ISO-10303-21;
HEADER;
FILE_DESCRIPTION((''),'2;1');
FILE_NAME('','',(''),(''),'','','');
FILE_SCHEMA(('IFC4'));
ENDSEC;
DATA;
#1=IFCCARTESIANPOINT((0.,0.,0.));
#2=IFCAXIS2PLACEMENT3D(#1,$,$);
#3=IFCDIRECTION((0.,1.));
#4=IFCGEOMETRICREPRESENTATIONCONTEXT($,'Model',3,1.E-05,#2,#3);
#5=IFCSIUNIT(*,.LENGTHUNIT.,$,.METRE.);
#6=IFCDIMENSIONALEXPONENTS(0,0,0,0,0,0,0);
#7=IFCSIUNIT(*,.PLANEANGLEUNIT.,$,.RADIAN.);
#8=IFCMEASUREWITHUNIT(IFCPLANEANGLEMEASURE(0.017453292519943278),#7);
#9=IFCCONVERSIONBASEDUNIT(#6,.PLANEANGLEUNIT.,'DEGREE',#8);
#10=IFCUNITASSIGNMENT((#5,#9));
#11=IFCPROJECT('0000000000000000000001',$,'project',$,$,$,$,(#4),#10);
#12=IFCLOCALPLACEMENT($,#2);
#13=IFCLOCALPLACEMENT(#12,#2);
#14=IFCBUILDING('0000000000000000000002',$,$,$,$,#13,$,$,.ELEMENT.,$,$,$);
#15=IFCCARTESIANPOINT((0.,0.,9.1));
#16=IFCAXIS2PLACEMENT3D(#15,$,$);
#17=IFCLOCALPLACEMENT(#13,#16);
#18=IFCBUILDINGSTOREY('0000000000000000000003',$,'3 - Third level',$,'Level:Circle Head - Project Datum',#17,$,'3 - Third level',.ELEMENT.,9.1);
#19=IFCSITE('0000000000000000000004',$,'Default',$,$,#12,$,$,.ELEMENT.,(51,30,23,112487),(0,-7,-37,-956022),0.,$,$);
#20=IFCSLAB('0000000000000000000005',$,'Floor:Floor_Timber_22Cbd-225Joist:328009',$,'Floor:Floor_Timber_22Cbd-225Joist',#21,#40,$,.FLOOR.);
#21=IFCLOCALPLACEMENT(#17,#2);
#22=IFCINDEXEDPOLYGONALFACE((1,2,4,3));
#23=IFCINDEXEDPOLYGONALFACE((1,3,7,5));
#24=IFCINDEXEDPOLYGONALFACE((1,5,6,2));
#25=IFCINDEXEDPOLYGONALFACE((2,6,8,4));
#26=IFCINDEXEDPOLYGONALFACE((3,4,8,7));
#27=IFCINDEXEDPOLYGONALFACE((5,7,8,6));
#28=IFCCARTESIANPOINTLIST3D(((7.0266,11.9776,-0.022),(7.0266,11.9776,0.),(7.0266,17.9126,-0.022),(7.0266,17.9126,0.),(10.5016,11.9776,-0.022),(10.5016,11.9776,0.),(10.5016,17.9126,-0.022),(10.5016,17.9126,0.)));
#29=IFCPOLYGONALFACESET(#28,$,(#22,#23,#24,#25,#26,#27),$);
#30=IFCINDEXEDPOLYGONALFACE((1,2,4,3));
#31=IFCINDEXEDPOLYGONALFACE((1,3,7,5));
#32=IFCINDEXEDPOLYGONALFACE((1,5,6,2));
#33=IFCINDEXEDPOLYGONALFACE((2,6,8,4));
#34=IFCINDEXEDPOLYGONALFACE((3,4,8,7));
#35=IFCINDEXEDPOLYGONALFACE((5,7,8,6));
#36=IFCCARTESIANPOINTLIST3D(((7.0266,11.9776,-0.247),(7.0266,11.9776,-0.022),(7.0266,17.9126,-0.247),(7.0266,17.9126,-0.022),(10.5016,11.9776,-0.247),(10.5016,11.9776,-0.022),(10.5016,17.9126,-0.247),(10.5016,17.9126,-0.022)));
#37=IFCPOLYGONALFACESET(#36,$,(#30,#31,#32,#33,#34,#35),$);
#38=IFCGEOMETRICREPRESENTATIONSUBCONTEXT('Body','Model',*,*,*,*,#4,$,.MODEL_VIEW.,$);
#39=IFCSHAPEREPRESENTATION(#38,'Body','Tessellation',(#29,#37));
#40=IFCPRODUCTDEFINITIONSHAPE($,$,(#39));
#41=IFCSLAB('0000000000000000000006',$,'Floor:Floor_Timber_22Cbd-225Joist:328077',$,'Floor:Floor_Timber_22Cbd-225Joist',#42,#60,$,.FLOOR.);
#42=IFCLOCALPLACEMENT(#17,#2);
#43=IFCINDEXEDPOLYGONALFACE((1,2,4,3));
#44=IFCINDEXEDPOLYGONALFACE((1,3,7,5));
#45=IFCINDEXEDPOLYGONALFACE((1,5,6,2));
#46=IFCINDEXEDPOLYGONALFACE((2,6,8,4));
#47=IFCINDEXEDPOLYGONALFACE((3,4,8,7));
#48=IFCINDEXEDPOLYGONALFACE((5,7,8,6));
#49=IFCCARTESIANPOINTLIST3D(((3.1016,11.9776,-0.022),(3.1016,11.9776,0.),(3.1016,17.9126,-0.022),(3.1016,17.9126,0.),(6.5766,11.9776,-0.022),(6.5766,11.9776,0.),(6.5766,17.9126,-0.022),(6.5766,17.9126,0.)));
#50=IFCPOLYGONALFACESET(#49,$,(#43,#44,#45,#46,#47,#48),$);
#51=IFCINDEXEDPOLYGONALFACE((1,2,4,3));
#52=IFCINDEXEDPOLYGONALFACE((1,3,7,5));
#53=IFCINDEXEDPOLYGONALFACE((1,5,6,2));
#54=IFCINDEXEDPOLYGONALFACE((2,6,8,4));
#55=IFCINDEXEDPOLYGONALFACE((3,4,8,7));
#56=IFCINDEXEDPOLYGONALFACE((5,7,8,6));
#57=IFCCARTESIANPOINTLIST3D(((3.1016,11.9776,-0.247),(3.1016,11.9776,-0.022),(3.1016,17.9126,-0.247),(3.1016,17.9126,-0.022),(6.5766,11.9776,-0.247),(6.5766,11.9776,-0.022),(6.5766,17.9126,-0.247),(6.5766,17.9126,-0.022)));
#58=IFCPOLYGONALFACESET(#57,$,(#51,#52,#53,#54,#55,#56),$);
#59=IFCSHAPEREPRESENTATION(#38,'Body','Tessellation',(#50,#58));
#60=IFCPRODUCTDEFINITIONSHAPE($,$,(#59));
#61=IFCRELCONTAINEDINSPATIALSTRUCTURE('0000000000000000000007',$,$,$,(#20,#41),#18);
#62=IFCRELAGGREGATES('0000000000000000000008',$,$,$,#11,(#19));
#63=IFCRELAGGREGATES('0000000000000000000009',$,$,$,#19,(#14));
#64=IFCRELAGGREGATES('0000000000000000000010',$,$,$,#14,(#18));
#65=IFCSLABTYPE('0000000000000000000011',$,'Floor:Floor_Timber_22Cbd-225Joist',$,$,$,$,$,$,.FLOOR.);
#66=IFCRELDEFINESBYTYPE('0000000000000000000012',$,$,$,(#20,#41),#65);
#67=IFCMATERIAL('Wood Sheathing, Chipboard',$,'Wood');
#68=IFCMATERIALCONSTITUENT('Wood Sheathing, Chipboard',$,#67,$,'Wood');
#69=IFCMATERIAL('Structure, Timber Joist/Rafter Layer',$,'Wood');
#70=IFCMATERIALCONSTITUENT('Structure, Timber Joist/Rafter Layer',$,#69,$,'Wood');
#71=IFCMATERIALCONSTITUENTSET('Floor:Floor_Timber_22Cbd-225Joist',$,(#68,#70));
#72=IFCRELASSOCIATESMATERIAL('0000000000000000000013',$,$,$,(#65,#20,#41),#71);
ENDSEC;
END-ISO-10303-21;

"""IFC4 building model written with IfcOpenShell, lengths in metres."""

from ifc_helpers import new_model, entity, si_unit, converted_unit, direction, frame, origin, place, context, subcontext, project, spatial, indexed_curve, outline, extrude, material, constituent, constituent_set, type_object, element, save


model = new_model("IFC4")

# Units and contexts
model_context = context("Model", 3, precision=1e-05, world=origin(), true_north=direction((0.0, 1.0)))
body_context = subcontext(model_context, "Body", "Model", "MODEL_VIEW")
ifc_project = project(units=[si_unit("LENGTHUNIT", "METRE"), converted_unit("PLANEANGLEUNIT", "DEGREE", entity("IfcPlaneAngleMeasure", 0.017453292519943278), si_unit("PLANEANGLEUNIT", "RADIAN"), dimensions=[0, 0, 0, 0, 0, 0, 0])], contexts=[model_context])

# Site, building, storey
site_placement = place(None, origin())
site = spatial("IfcSite", under=ifc_project, at=site_placement, Name="Default", CompositionType="ELEMENT", RefLatitude=(51, 30, 23, 112487), RefLongitude=(0, -7, -37, -956022), RefElevation=0.0)
building_placement = place(site_placement, origin())
building = spatial("IfcBuilding", under=site, at=building_placement, CompositionType="ELEMENT")
storey_placement = place(building_placement, frame((0.0, 0.0, 9.1)))
storey = spatial("IfcBuildingStorey", under=building, at=storey_placement, Name="3 - Third level", ObjectType="Level:Circle Head - Project Datum", LongName="3 - Third level", CompositionType="ELEMENT", Elevation=9.1)

# Slabs
ifc_material_1 = material(Name="Wood Sheathing, Chipboard", Category="Wood")
ifc_constituent_1 = constituent(ifc_material_1, Name="Wood Sheathing, Chipboard", Category="Wood")
ifc_material_2 = material(Name="Structure, Timber Joist/Rafter Layer", Category="Wood")
ifc_constituent_2 = constituent(ifc_material_2, Name="Structure, Timber Joist/Rafter Layer", Category="Wood")
ifc_constituent_set = constituent_set(constituents=[ifc_constituent_1, ifc_constituent_2], Name="Floor:Floor_Timber_22Cbd-225Joist")
slab_type = type_object("IfcSlabType", Name="Floor:Floor_Timber_22Cbd-225Joist", PredefinedType="FLOOR", material=ifc_constituent_set)
slab_1_placement = place(storey_placement, origin())
element("IfcSlab", 1, at=slab_1_placement, inside=storey, type_object=slab_type, material=ifc_constituent_set, Name="Floor:Floor_Timber_22Cbd-225Joist:328009", ObjectType="Floor:Floor_Timber_22Cbd-225Joist", PredefinedType="FLOOR", context=body_context, shape_type="SweptSolid", body=[
    extrude(outline(indexed_curve([(-2.9675, -1.7375), (2.9675, -1.7375), (2.9675, 1.7375), (-2.9675, 1.7375), (-2.9675, -1.7375)], self_intersect=False)), frame((8.7641, 14.9451, -0.022), z_axis=(0.0, 0.0, 1.0), x_axis=(0.0, -1.0, 0.0)), (0.0, 0.0, 1.0), 0.022),
    extrude(outline(indexed_curve([(-2.9675, -1.7375), (2.9675, -1.7375), (2.9675, 1.7375), (-2.9675, 1.7375), (-2.9675, -1.7375)], self_intersect=False)), frame((8.7641, 14.9451, -0.247), z_axis=(0.0, 0.0, 1.0), x_axis=(0.0, -1.0, 0.0)), (0.0, 0.0, 1.0), 0.225),
])
slab_2_placement = place(storey_placement, origin())
element("IfcSlab", 2, at=slab_2_placement, inside=storey, type_object=slab_type, material=ifc_constituent_set, Name="Floor:Floor_Timber_22Cbd-225Joist:328077", ObjectType="Floor:Floor_Timber_22Cbd-225Joist", PredefinedType="FLOOR", context=body_context, shape_type="SweptSolid", body=[
    extrude(outline(indexed_curve([(-1.7375, -2.9675), (1.7375, -2.9675), (1.7375, 2.9675), (-1.7375, 2.9675), (-1.7375, -2.9675)], self_intersect=False)), frame((4.8391, 14.9451, -0.022), z_axis=(0.0, 0.0, 1.0), x_axis=(-1.0, 0.0, 0.0)), (0.0, 0.0, 1.0), 0.022),
    extrude(outline(indexed_curve([(-1.7375, -2.9675), (1.7375, -2.9675), (1.7375, 2.9675), (-1.7375, 2.9675), (-1.7375, -2.9675)], self_intersect=False)), frame((4.8391, 14.9451, -0.247), z_axis=(0.0, 0.0, 1.0), x_axis=(-1.0, 0.0, 0.0)), (0.0, 0.0, 1.0), 0.225),
])

save(model, "model.ifc")
